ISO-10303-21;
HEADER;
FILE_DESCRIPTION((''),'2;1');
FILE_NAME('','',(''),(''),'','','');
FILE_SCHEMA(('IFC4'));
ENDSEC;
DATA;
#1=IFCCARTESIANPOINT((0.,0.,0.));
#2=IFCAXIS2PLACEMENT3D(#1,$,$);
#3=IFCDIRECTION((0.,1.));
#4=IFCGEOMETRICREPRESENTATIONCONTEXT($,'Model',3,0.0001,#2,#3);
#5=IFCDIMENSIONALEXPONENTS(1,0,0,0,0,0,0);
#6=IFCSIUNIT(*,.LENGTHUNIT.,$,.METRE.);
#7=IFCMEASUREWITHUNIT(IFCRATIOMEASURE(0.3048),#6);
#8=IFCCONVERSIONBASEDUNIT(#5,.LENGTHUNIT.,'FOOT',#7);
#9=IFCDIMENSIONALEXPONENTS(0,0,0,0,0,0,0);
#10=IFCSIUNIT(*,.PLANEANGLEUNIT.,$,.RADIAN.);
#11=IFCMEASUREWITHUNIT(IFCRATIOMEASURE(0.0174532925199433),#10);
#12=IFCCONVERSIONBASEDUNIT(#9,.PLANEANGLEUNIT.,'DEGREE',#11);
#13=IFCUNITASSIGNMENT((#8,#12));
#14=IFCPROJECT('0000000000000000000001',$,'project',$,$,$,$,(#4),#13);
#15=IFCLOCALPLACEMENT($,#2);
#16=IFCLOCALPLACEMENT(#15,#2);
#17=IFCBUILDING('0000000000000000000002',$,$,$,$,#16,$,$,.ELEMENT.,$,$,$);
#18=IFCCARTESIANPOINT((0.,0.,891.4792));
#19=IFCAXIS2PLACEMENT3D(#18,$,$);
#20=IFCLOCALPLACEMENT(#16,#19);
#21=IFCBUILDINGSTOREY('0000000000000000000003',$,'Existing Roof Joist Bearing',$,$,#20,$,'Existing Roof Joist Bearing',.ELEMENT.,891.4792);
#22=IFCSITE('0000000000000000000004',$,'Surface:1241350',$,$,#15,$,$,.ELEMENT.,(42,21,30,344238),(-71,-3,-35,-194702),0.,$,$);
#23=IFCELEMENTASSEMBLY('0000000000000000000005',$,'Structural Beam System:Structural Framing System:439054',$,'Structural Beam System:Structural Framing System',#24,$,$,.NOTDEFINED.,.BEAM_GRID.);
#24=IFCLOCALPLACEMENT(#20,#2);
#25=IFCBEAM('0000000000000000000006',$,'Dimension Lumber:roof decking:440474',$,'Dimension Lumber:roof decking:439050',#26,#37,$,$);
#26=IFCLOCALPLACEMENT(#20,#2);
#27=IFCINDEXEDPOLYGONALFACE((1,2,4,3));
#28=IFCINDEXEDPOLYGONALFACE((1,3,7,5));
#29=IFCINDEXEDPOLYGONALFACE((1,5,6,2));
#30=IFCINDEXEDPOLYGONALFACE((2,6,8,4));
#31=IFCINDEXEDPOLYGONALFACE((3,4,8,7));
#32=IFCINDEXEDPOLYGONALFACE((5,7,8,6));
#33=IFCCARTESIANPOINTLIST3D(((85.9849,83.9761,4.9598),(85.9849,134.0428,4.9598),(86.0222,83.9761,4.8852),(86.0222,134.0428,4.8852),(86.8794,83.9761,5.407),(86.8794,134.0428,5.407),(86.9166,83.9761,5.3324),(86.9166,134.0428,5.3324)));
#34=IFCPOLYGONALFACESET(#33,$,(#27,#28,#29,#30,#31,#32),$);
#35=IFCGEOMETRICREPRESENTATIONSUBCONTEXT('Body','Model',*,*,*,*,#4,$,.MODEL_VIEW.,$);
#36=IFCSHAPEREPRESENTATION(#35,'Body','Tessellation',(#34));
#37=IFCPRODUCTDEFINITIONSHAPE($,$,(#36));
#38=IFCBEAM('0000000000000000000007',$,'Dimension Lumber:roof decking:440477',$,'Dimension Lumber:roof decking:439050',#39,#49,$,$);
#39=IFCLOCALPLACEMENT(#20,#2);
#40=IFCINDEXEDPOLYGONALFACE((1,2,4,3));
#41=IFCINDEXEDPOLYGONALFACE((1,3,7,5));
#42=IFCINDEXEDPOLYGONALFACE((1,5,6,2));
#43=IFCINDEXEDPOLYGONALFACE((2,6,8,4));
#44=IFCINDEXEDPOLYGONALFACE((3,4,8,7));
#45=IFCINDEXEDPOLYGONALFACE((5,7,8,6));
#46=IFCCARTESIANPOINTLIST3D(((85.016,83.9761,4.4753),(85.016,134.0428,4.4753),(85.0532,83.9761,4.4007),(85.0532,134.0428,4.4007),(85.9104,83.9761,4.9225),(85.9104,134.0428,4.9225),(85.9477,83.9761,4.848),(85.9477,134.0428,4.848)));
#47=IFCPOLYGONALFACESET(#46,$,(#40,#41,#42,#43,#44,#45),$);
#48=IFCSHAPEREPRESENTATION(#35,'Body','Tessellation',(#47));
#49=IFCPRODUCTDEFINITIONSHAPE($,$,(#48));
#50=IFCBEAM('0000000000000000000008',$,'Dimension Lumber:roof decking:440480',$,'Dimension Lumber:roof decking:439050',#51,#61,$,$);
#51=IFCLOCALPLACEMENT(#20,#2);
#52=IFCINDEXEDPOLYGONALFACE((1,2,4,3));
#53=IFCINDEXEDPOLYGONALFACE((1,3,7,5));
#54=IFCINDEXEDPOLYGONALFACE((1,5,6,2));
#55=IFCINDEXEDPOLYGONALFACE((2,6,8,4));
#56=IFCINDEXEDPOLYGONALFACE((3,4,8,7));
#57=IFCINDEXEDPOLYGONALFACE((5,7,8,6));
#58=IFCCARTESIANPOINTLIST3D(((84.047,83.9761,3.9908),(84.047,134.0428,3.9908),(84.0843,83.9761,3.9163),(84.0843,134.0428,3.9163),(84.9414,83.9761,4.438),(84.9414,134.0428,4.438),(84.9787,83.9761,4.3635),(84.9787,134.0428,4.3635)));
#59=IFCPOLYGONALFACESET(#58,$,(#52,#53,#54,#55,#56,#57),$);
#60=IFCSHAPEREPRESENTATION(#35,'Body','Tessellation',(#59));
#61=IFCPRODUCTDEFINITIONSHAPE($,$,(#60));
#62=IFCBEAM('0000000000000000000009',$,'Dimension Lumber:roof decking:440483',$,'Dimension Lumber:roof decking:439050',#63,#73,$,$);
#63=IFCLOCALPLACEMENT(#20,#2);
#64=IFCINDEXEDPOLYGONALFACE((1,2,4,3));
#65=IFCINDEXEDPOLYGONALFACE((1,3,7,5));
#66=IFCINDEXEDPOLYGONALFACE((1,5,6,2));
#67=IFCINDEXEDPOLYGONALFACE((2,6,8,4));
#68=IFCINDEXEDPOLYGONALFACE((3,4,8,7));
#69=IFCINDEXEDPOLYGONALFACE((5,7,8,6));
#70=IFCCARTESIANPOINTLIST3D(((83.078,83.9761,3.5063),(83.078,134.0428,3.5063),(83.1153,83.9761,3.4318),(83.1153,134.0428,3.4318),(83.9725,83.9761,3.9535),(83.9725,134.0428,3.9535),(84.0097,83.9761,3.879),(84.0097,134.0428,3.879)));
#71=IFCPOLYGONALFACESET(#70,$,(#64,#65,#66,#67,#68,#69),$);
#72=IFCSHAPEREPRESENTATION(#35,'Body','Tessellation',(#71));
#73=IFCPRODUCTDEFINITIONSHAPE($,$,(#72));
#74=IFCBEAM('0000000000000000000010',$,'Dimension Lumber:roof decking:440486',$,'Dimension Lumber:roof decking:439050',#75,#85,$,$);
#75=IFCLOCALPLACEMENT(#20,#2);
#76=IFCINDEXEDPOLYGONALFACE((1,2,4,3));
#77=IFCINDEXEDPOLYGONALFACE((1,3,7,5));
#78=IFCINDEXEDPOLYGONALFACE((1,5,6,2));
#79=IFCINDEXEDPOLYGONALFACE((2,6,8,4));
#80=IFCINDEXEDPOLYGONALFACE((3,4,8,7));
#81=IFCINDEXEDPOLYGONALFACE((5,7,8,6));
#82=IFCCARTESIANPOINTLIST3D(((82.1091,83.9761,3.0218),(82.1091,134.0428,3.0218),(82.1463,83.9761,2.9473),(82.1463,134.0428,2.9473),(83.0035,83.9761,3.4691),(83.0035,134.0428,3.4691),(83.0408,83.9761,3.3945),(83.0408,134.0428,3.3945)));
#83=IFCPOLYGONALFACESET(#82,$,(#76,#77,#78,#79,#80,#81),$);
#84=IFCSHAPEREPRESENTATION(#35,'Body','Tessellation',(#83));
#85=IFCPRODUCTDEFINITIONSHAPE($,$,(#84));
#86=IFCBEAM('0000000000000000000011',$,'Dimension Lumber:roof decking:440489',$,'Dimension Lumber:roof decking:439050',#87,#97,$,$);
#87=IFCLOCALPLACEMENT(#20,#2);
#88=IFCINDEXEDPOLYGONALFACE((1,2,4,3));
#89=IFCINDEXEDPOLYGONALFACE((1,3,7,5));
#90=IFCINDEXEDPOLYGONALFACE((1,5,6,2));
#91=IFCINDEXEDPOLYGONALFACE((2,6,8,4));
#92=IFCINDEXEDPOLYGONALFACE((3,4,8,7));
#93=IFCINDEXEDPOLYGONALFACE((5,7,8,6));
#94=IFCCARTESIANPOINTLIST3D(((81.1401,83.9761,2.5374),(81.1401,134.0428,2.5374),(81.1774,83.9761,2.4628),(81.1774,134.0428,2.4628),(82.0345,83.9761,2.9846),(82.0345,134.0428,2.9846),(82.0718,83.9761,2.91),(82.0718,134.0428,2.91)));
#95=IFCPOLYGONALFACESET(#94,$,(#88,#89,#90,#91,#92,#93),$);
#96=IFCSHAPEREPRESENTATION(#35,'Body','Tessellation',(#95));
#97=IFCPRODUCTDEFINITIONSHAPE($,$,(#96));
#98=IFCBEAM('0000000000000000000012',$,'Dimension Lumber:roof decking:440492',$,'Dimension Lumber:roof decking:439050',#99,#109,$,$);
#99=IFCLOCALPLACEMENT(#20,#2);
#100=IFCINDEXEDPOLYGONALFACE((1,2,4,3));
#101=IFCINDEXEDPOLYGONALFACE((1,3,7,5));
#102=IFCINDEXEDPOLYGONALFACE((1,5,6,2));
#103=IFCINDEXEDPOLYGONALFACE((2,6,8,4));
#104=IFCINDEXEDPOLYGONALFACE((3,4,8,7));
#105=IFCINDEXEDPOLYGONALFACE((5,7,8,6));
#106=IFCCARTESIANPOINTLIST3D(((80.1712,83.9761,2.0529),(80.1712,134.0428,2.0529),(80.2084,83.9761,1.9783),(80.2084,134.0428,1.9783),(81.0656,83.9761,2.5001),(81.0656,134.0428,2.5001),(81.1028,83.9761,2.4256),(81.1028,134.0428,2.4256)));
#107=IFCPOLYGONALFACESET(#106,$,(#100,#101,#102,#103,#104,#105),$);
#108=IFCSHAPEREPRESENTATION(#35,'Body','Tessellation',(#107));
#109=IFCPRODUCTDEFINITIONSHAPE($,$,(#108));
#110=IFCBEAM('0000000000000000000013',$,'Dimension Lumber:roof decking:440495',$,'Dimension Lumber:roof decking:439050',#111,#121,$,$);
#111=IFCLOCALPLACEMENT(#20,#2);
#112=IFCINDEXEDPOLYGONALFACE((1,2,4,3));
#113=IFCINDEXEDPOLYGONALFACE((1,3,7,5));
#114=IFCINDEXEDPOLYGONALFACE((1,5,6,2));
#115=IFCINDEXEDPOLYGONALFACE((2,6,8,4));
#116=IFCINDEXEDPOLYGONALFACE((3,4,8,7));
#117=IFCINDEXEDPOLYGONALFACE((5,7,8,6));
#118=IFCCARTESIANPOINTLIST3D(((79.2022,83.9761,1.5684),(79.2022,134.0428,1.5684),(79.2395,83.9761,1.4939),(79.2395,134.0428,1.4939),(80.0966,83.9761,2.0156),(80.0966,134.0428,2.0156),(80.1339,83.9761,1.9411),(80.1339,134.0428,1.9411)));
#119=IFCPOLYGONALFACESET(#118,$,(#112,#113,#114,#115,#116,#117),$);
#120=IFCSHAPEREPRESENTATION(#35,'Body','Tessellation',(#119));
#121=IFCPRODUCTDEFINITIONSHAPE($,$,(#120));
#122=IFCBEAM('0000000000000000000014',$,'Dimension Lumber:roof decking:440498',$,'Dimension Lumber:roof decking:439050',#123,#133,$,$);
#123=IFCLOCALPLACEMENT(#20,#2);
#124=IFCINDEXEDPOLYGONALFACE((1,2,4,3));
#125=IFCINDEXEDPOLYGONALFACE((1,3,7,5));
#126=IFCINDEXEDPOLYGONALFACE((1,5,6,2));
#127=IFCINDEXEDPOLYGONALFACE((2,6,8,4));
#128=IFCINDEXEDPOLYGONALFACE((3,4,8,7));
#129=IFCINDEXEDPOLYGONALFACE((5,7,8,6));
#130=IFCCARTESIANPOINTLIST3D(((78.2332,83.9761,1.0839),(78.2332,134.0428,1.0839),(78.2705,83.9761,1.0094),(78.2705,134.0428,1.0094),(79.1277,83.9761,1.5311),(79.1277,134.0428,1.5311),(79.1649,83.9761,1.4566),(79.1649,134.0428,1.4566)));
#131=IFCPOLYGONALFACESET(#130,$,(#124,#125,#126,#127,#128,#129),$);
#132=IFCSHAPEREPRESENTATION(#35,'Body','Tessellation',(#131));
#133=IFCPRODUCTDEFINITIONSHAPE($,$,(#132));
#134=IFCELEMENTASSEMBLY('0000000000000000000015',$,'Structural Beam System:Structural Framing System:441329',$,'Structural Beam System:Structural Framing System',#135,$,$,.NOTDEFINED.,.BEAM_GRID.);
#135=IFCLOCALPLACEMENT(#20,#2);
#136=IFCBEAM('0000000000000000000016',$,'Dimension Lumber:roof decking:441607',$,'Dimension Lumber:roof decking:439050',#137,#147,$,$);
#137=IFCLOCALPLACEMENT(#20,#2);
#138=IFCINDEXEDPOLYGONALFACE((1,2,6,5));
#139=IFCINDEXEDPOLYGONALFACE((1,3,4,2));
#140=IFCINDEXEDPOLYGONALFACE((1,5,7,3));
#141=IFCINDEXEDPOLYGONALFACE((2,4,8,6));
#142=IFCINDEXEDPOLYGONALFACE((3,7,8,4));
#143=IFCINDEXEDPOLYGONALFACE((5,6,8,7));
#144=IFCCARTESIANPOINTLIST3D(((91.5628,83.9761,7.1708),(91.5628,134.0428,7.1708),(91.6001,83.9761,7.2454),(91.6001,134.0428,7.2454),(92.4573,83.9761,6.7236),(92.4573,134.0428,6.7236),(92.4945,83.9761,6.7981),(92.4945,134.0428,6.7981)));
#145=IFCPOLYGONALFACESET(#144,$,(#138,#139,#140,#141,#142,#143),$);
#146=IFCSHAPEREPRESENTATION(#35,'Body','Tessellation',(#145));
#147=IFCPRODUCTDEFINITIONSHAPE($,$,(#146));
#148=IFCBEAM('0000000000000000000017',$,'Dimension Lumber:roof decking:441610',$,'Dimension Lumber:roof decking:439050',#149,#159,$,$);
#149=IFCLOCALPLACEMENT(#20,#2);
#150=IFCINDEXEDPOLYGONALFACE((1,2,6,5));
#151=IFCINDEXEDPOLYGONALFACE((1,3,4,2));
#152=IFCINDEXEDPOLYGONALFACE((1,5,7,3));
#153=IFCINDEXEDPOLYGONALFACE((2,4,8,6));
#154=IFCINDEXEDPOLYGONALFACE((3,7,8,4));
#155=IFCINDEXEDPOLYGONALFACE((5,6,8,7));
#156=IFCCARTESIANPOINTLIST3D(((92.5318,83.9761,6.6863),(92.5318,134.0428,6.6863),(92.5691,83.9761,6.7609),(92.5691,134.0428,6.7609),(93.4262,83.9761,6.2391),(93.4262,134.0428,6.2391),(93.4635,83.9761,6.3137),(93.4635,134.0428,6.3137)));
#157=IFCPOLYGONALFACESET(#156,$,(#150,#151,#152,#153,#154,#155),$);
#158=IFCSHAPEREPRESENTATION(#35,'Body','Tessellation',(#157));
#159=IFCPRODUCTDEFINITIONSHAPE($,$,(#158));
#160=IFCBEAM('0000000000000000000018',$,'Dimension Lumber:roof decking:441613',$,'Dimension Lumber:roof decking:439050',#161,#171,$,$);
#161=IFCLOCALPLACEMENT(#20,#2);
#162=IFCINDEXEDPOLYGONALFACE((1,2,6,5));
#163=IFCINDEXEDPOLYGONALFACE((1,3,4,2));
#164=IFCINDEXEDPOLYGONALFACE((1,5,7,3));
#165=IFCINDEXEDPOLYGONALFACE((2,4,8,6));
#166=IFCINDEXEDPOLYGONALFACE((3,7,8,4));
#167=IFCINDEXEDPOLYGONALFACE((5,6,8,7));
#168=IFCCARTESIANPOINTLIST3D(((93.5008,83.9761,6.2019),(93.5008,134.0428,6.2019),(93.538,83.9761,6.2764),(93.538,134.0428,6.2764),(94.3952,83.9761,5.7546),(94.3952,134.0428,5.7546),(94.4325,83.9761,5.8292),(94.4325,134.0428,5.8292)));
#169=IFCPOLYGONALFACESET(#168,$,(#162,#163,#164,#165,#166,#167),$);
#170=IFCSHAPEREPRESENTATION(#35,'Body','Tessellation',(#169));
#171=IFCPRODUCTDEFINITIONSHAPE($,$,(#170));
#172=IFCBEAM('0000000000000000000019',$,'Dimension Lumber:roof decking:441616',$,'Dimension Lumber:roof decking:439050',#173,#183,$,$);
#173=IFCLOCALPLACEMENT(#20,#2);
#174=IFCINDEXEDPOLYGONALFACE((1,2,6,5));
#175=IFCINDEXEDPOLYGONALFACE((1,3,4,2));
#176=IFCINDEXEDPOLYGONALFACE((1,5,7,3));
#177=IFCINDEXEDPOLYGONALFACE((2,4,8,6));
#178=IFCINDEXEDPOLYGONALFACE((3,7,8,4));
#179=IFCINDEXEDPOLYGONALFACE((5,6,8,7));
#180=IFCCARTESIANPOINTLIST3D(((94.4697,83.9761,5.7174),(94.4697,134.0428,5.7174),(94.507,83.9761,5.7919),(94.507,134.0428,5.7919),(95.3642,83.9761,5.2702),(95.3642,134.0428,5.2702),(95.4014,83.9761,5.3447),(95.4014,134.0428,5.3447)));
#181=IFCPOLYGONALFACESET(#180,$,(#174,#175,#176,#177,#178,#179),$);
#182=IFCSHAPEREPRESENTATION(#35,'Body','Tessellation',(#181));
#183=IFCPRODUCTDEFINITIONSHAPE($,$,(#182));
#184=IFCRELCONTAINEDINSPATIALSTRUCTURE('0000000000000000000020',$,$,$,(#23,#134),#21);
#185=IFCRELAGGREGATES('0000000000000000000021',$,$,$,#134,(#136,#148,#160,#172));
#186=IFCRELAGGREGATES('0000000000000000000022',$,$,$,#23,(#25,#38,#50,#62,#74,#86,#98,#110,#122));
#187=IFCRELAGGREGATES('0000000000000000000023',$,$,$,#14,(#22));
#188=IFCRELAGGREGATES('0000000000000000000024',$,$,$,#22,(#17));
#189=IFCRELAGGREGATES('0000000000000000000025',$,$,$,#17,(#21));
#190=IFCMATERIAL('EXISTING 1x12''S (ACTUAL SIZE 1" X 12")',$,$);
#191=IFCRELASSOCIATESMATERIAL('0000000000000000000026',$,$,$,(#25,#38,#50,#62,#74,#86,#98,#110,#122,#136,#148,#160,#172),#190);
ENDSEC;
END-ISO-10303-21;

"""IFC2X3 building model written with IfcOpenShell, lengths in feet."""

from ifc_helpers import new_model, entity, si_unit, converted_unit, direction, frame, frame_2d, origin, place, context, subcontext, project, spatial, rectangle, extrude, material, element, aggregate, save


model = new_model("IFC2X3")

# Units and contexts
model_context = context("Model", 3, precision=0.0001, world=origin(), true_north=direction((0.0, 1.0)))
body_context = subcontext(model_context, "Body", "Model", "MODEL_VIEW")
ifc_project = project(units=[converted_unit("LENGTHUNIT", "FOOT", entity("IfcRatioMeasure", 0.3048), si_unit("LENGTHUNIT", "METRE"), dimensions=[1, 0, 0, 0, 0, 0, 0]), converted_unit("PLANEANGLEUNIT", "DEGREE", entity("IfcRatioMeasure", 0.0174532925199433), si_unit("PLANEANGLEUNIT", "RADIAN"), dimensions=[0, 0, 0, 0, 0, 0, 0])], contexts=[model_context])

# Site, building, storey
site_placement = place(None, origin())
site = spatial("IfcSite", under=ifc_project, at=site_placement, Name="Surface:1241350", CompositionType="ELEMENT", RefLatitude=(42, 21, 30, 344238), RefLongitude=(-71, -3, -35, -194702), RefElevation=0.0)
building_placement = place(site_placement, origin())
building = spatial("IfcBuilding", under=site, at=building_placement, CompositionType="ELEMENT")
storey_placement = place(building_placement, frame((0.0, 0.0, 891.4792)))
storey = spatial("IfcBuildingStorey", under=building, at=storey_placement, Name="Existing Roof Joist Bearing", LongName="Existing Roof Joist Bearing", CompositionType="ELEMENT", Elevation=891.4792)

# Element assemblies, beams
assembly_1_placement = place(storey_placement, origin())
assembly_1 = element("IfcElementAssembly", 1, at=assembly_1_placement, inside=storey, Name="Structural Beam System:Structural Framing System:439054", ObjectType="Structural Beam System:Structural Framing System", AssemblyPlace="NOTDEFINED", PredefinedType="BEAM_GRID")
ifc_material_1 = material(Name="EXISTING 1x12'S (ACTUAL SIZE 1\" X 12\")")
beam_1_placement = place(assembly_1_placement, frame((86.4321, 83.9761, 5.1834), z_axis=(0.0, 0.0, 1.0), x_axis=(0.0, 1.0, 0.0)))
beam_1 = element("IfcBeam", 2, at=beam_1_placement, material=ifc_material_1, Name="Dimension Lumber:roof decking:440474", ObjectType="Dimension Lumber:roof decking:439050", context=body_context, shape_type="SweptSolid", body=[
    extrude(rectangle(XDim=0.0833, YDim=1.0, at=frame_2d((0.0, 0.0), x_axis=(0.0, 1.0))), frame((0.0, -0.0186, -0.0373), z_axis=(1.0, 0.0, 0.0), x_axis=(0.0, -0.894427, 0.447214)), (0.0, 0.0, 1.0), 50.0667),
])
beam_2_placement = place(assembly_1_placement, frame((85.4632, 83.9761, 4.6989), z_axis=(0.0, 0.0, 1.0), x_axis=(0.0, 1.0, 0.0)))
beam_2 = element("IfcBeam", 3, at=beam_2_placement, material=ifc_material_1, Name="Dimension Lumber:roof decking:440477", ObjectType="Dimension Lumber:roof decking:439050", context=body_context, shape_type="SweptSolid", body=[
    extrude(rectangle(XDim=0.0833, YDim=1.0, at=frame_2d((0.0, 0.0), x_axis=(0.0, 1.0))), frame((0.0, -0.0186, -0.0373), z_axis=(1.0, 0.0, 0.0), x_axis=(0.0, -0.894427, 0.447214)), (0.0, 0.0, 1.0), 50.0667),
])
beam_3_placement = place(assembly_1_placement, frame((84.4942, 83.9761, 4.2144), z_axis=(0.0, 0.0, 1.0), x_axis=(0.0, 1.0, 0.0)))
beam_3 = element("IfcBeam", 4, at=beam_3_placement, material=ifc_material_1, Name="Dimension Lumber:roof decking:440480", ObjectType="Dimension Lumber:roof decking:439050", context=body_context, shape_type="SweptSolid", body=[
    extrude(rectangle(XDim=0.0833, YDim=1.0, at=frame_2d((0.0, 0.0), x_axis=(0.0, 1.0))), frame((0.0, -0.0186, -0.0373), z_axis=(1.0, 0.0, 0.0), x_axis=(0.0, -0.894427, 0.447214)), (0.0, 0.0, 1.0), 50.0667),
])
beam_4_placement = place(assembly_1_placement, frame((83.5253, 83.9761, 3.7299), z_axis=(0.0, 0.0, 1.0), x_axis=(0.0, 1.0, 0.0)))
beam_4 = element("IfcBeam", 5, at=beam_4_placement, material=ifc_material_1, Name="Dimension Lumber:roof decking:440483", ObjectType="Dimension Lumber:roof decking:439050", context=body_context, shape_type="SweptSolid", body=[
    extrude(rectangle(XDim=0.0833, YDim=1.0, at=frame_2d((0.0, 0.0), x_axis=(0.0, 1.0))), frame((0.0, -0.0186, -0.0373), z_axis=(1.0, 0.0, 0.0), x_axis=(0.0, -0.894427, 0.447214)), (0.0, 0.0, 1.0), 50.0667),
])
beam_5_placement = place(assembly_1_placement, frame((82.5563, 83.9761, 3.2454), z_axis=(0.0, 0.0, 1.0), x_axis=(0.0, 1.0, 0.0)))
beam_5 = element("IfcBeam", 6, at=beam_5_placement, material=ifc_material_1, Name="Dimension Lumber:roof decking:440486", ObjectType="Dimension Lumber:roof decking:439050", context=body_context, shape_type="SweptSolid", body=[
    extrude(rectangle(XDim=0.0833, YDim=1.0, at=frame_2d((0.0, 0.0), x_axis=(0.0, 1.0))), frame((0.0, -0.0186, -0.0373), z_axis=(1.0, 0.0, 0.0), x_axis=(0.0, -0.894427, 0.447214)), (0.0, 0.0, 1.0), 50.0667),
])
beam_6_placement = place(assembly_1_placement, frame((81.5873, 83.9761, 2.761), z_axis=(0.0, 0.0, 1.0), x_axis=(0.0, 1.0, 0.0)))
beam_6 = element("IfcBeam", 7, at=beam_6_placement, material=ifc_material_1, Name="Dimension Lumber:roof decking:440489", ObjectType="Dimension Lumber:roof decking:439050", context=body_context, shape_type="SweptSolid", body=[
    extrude(rectangle(XDim=0.0833, YDim=1.0, at=frame_2d((0.0, 0.0), x_axis=(0.0, 1.0))), frame((0.0, -0.0186, -0.0373), z_axis=(1.0, 0.0, 0.0), x_axis=(0.0, -0.894427, 0.447214)), (0.0, 0.0, 1.0), 50.0667),
])
beam_7_placement = place(assembly_1_placement, frame((80.6184, 83.9761, 2.2765), z_axis=(0.0, 0.0, 1.0), x_axis=(0.0, 1.0, 0.0)))
beam_7 = element("IfcBeam", 8, at=beam_7_placement, material=ifc_material_1, Name="Dimension Lumber:roof decking:440492", ObjectType="Dimension Lumber:roof decking:439050", context=body_context, shape_type="SweptSolid", body=[
    extrude(rectangle(XDim=0.0833, YDim=1.0, at=frame_2d((0.0, 0.0), x_axis=(0.0, 1.0))), frame((0.0, -0.0186, -0.0373), z_axis=(1.0, 0.0, 0.0), x_axis=(0.0, -0.894427, 0.447214)), (0.0, 0.0, 1.0), 50.0667),
])
beam_8_placement = place(assembly_1_placement, frame((79.6494, 83.9761, 1.792), z_axis=(0.0, 0.0, 1.0), x_axis=(0.0, 1.0, 0.0)))
beam_8 = element("IfcBeam", 9, at=beam_8_placement, material=ifc_material_1, Name="Dimension Lumber:roof decking:440495", ObjectType="Dimension Lumber:roof decking:439050", context=body_context, shape_type="SweptSolid", body=[
    extrude(rectangle(XDim=0.0833, YDim=1.0, at=frame_2d((0.0, 0.0), x_axis=(0.0, 1.0))), frame((0.0, -0.0186, -0.0373), z_axis=(1.0, 0.0, 0.0), x_axis=(0.0, -0.894427, 0.447214)), (0.0, 0.0, 1.0), 50.0667),
])
beam_9_placement = place(assembly_1_placement, frame((78.6804, 83.9761, 1.3075), z_axis=(0.0, 0.0, 1.0), x_axis=(0.0, 1.0, 0.0)))
beam_9 = element("IfcBeam", 10, at=beam_9_placement, material=ifc_material_1, Name="Dimension Lumber:roof decking:440498", ObjectType="Dimension Lumber:roof decking:439050", context=body_context, shape_type="SweptSolid", body=[
    extrude(rectangle(XDim=0.0833, YDim=1.0, at=frame_2d((0.0, 0.0), x_axis=(0.0, 1.0))), frame((0.0, -0.0186, -0.0373), z_axis=(1.0, 0.0, 0.0), x_axis=(0.0, -0.894427, 0.447214)), (0.0, 0.0, 1.0), 50.0667),
])
assembly_2_placement = place(storey_placement, origin())
assembly_2 = element("IfcElementAssembly", 11, at=assembly_2_placement, inside=storey, Name="Structural Beam System:Structural Framing System:441329", ObjectType="Structural Beam System:Structural Framing System", AssemblyPlace="NOTDEFINED", PredefinedType="BEAM_GRID")
beam_10_placement = place(assembly_2_placement, frame((92.0473, 83.9761, 7.0217), z_axis=(0.0, 0.0, 1.0), x_axis=(0.0, 1.0, 0.0)))
beam_10 = element("IfcBeam", 12, at=beam_10_placement, material=ifc_material_1, Name="Dimension Lumber:roof decking:441607", ObjectType="Dimension Lumber:roof decking:439050", context=body_context, shape_type="SweptSolid", body=[
    extrude(rectangle(XDim=0.0833, YDim=1.0, at=frame_2d((0.0, 0.0), x_axis=(0.0, 1.0))), frame((0.0, 0.0186, -0.0373), z_axis=(1.0, 0.0, 0.0), x_axis=(0.0, -0.894427, -0.447214)), (0.0, 0.0, 1.0), 50.0667),
])
beam_11_placement = place(assembly_2_placement, frame((93.0163, 83.9761, 6.5373), z_axis=(0.0, 0.0, 1.0), x_axis=(0.0, 1.0, 0.0)))
beam_11 = element("IfcBeam", 13, at=beam_11_placement, material=ifc_material_1, Name="Dimension Lumber:roof decking:441610", ObjectType="Dimension Lumber:roof decking:439050", context=body_context, shape_type="SweptSolid", body=[
    extrude(rectangle(XDim=0.0833, YDim=1.0, at=frame_2d((0.0, 0.0), x_axis=(0.0, 1.0))), frame((0.0, 0.0186, -0.0373), z_axis=(1.0, 0.0, 0.0), x_axis=(0.0, -0.894427, -0.447214)), (0.0, 0.0, 1.0), 50.0667),
])
beam_12_placement = place(assembly_2_placement, frame((93.9852, 83.9761, 6.0528), z_axis=(0.0, 0.0, 1.0), x_axis=(0.0, 1.0, 0.0)))
beam_12 = element("IfcBeam", 14, at=beam_12_placement, material=ifc_material_1, Name="Dimension Lumber:roof decking:441613", ObjectType="Dimension Lumber:roof decking:439050", context=body_context, shape_type="SweptSolid", body=[
    extrude(rectangle(XDim=0.0833, YDim=1.0, at=frame_2d((0.0, 0.0), x_axis=(0.0, 1.0))), frame((0.0, 0.0186, -0.0373), z_axis=(1.0, 0.0, 0.0), x_axis=(0.0, -0.894427, -0.447214)), (0.0, 0.0, 1.0), 50.0667),
])
beam_13_placement = place(assembly_2_placement, frame((94.9542, 83.9761, 5.5683), z_axis=(0.0, 0.0, 1.0), x_axis=(0.0, 1.0, 0.0)))
beam_13 = element("IfcBeam", 15, at=beam_13_placement, material=ifc_material_1, Name="Dimension Lumber:roof decking:441616", ObjectType="Dimension Lumber:roof decking:439050", context=body_context, shape_type="SweptSolid", body=[
    extrude(rectangle(XDim=0.0833, YDim=1.0, at=frame_2d((0.0, 0.0), x_axis=(0.0, 1.0))), frame((0.0, 0.0186, -0.0373), z_axis=(1.0, 0.0, 0.0), x_axis=(0.0, -0.894427, -0.447214)), (0.0, 0.0, 1.0), 50.0667),
])
aggregate(assembly_2, [beam_10, beam_11, beam_12, beam_13])

aggregate(assembly_1, [beam_1, beam_2, beam_3, beam_4, beam_5, beam_6, beam_7, beam_8, beam_9])

save(model, "model.ifc")
